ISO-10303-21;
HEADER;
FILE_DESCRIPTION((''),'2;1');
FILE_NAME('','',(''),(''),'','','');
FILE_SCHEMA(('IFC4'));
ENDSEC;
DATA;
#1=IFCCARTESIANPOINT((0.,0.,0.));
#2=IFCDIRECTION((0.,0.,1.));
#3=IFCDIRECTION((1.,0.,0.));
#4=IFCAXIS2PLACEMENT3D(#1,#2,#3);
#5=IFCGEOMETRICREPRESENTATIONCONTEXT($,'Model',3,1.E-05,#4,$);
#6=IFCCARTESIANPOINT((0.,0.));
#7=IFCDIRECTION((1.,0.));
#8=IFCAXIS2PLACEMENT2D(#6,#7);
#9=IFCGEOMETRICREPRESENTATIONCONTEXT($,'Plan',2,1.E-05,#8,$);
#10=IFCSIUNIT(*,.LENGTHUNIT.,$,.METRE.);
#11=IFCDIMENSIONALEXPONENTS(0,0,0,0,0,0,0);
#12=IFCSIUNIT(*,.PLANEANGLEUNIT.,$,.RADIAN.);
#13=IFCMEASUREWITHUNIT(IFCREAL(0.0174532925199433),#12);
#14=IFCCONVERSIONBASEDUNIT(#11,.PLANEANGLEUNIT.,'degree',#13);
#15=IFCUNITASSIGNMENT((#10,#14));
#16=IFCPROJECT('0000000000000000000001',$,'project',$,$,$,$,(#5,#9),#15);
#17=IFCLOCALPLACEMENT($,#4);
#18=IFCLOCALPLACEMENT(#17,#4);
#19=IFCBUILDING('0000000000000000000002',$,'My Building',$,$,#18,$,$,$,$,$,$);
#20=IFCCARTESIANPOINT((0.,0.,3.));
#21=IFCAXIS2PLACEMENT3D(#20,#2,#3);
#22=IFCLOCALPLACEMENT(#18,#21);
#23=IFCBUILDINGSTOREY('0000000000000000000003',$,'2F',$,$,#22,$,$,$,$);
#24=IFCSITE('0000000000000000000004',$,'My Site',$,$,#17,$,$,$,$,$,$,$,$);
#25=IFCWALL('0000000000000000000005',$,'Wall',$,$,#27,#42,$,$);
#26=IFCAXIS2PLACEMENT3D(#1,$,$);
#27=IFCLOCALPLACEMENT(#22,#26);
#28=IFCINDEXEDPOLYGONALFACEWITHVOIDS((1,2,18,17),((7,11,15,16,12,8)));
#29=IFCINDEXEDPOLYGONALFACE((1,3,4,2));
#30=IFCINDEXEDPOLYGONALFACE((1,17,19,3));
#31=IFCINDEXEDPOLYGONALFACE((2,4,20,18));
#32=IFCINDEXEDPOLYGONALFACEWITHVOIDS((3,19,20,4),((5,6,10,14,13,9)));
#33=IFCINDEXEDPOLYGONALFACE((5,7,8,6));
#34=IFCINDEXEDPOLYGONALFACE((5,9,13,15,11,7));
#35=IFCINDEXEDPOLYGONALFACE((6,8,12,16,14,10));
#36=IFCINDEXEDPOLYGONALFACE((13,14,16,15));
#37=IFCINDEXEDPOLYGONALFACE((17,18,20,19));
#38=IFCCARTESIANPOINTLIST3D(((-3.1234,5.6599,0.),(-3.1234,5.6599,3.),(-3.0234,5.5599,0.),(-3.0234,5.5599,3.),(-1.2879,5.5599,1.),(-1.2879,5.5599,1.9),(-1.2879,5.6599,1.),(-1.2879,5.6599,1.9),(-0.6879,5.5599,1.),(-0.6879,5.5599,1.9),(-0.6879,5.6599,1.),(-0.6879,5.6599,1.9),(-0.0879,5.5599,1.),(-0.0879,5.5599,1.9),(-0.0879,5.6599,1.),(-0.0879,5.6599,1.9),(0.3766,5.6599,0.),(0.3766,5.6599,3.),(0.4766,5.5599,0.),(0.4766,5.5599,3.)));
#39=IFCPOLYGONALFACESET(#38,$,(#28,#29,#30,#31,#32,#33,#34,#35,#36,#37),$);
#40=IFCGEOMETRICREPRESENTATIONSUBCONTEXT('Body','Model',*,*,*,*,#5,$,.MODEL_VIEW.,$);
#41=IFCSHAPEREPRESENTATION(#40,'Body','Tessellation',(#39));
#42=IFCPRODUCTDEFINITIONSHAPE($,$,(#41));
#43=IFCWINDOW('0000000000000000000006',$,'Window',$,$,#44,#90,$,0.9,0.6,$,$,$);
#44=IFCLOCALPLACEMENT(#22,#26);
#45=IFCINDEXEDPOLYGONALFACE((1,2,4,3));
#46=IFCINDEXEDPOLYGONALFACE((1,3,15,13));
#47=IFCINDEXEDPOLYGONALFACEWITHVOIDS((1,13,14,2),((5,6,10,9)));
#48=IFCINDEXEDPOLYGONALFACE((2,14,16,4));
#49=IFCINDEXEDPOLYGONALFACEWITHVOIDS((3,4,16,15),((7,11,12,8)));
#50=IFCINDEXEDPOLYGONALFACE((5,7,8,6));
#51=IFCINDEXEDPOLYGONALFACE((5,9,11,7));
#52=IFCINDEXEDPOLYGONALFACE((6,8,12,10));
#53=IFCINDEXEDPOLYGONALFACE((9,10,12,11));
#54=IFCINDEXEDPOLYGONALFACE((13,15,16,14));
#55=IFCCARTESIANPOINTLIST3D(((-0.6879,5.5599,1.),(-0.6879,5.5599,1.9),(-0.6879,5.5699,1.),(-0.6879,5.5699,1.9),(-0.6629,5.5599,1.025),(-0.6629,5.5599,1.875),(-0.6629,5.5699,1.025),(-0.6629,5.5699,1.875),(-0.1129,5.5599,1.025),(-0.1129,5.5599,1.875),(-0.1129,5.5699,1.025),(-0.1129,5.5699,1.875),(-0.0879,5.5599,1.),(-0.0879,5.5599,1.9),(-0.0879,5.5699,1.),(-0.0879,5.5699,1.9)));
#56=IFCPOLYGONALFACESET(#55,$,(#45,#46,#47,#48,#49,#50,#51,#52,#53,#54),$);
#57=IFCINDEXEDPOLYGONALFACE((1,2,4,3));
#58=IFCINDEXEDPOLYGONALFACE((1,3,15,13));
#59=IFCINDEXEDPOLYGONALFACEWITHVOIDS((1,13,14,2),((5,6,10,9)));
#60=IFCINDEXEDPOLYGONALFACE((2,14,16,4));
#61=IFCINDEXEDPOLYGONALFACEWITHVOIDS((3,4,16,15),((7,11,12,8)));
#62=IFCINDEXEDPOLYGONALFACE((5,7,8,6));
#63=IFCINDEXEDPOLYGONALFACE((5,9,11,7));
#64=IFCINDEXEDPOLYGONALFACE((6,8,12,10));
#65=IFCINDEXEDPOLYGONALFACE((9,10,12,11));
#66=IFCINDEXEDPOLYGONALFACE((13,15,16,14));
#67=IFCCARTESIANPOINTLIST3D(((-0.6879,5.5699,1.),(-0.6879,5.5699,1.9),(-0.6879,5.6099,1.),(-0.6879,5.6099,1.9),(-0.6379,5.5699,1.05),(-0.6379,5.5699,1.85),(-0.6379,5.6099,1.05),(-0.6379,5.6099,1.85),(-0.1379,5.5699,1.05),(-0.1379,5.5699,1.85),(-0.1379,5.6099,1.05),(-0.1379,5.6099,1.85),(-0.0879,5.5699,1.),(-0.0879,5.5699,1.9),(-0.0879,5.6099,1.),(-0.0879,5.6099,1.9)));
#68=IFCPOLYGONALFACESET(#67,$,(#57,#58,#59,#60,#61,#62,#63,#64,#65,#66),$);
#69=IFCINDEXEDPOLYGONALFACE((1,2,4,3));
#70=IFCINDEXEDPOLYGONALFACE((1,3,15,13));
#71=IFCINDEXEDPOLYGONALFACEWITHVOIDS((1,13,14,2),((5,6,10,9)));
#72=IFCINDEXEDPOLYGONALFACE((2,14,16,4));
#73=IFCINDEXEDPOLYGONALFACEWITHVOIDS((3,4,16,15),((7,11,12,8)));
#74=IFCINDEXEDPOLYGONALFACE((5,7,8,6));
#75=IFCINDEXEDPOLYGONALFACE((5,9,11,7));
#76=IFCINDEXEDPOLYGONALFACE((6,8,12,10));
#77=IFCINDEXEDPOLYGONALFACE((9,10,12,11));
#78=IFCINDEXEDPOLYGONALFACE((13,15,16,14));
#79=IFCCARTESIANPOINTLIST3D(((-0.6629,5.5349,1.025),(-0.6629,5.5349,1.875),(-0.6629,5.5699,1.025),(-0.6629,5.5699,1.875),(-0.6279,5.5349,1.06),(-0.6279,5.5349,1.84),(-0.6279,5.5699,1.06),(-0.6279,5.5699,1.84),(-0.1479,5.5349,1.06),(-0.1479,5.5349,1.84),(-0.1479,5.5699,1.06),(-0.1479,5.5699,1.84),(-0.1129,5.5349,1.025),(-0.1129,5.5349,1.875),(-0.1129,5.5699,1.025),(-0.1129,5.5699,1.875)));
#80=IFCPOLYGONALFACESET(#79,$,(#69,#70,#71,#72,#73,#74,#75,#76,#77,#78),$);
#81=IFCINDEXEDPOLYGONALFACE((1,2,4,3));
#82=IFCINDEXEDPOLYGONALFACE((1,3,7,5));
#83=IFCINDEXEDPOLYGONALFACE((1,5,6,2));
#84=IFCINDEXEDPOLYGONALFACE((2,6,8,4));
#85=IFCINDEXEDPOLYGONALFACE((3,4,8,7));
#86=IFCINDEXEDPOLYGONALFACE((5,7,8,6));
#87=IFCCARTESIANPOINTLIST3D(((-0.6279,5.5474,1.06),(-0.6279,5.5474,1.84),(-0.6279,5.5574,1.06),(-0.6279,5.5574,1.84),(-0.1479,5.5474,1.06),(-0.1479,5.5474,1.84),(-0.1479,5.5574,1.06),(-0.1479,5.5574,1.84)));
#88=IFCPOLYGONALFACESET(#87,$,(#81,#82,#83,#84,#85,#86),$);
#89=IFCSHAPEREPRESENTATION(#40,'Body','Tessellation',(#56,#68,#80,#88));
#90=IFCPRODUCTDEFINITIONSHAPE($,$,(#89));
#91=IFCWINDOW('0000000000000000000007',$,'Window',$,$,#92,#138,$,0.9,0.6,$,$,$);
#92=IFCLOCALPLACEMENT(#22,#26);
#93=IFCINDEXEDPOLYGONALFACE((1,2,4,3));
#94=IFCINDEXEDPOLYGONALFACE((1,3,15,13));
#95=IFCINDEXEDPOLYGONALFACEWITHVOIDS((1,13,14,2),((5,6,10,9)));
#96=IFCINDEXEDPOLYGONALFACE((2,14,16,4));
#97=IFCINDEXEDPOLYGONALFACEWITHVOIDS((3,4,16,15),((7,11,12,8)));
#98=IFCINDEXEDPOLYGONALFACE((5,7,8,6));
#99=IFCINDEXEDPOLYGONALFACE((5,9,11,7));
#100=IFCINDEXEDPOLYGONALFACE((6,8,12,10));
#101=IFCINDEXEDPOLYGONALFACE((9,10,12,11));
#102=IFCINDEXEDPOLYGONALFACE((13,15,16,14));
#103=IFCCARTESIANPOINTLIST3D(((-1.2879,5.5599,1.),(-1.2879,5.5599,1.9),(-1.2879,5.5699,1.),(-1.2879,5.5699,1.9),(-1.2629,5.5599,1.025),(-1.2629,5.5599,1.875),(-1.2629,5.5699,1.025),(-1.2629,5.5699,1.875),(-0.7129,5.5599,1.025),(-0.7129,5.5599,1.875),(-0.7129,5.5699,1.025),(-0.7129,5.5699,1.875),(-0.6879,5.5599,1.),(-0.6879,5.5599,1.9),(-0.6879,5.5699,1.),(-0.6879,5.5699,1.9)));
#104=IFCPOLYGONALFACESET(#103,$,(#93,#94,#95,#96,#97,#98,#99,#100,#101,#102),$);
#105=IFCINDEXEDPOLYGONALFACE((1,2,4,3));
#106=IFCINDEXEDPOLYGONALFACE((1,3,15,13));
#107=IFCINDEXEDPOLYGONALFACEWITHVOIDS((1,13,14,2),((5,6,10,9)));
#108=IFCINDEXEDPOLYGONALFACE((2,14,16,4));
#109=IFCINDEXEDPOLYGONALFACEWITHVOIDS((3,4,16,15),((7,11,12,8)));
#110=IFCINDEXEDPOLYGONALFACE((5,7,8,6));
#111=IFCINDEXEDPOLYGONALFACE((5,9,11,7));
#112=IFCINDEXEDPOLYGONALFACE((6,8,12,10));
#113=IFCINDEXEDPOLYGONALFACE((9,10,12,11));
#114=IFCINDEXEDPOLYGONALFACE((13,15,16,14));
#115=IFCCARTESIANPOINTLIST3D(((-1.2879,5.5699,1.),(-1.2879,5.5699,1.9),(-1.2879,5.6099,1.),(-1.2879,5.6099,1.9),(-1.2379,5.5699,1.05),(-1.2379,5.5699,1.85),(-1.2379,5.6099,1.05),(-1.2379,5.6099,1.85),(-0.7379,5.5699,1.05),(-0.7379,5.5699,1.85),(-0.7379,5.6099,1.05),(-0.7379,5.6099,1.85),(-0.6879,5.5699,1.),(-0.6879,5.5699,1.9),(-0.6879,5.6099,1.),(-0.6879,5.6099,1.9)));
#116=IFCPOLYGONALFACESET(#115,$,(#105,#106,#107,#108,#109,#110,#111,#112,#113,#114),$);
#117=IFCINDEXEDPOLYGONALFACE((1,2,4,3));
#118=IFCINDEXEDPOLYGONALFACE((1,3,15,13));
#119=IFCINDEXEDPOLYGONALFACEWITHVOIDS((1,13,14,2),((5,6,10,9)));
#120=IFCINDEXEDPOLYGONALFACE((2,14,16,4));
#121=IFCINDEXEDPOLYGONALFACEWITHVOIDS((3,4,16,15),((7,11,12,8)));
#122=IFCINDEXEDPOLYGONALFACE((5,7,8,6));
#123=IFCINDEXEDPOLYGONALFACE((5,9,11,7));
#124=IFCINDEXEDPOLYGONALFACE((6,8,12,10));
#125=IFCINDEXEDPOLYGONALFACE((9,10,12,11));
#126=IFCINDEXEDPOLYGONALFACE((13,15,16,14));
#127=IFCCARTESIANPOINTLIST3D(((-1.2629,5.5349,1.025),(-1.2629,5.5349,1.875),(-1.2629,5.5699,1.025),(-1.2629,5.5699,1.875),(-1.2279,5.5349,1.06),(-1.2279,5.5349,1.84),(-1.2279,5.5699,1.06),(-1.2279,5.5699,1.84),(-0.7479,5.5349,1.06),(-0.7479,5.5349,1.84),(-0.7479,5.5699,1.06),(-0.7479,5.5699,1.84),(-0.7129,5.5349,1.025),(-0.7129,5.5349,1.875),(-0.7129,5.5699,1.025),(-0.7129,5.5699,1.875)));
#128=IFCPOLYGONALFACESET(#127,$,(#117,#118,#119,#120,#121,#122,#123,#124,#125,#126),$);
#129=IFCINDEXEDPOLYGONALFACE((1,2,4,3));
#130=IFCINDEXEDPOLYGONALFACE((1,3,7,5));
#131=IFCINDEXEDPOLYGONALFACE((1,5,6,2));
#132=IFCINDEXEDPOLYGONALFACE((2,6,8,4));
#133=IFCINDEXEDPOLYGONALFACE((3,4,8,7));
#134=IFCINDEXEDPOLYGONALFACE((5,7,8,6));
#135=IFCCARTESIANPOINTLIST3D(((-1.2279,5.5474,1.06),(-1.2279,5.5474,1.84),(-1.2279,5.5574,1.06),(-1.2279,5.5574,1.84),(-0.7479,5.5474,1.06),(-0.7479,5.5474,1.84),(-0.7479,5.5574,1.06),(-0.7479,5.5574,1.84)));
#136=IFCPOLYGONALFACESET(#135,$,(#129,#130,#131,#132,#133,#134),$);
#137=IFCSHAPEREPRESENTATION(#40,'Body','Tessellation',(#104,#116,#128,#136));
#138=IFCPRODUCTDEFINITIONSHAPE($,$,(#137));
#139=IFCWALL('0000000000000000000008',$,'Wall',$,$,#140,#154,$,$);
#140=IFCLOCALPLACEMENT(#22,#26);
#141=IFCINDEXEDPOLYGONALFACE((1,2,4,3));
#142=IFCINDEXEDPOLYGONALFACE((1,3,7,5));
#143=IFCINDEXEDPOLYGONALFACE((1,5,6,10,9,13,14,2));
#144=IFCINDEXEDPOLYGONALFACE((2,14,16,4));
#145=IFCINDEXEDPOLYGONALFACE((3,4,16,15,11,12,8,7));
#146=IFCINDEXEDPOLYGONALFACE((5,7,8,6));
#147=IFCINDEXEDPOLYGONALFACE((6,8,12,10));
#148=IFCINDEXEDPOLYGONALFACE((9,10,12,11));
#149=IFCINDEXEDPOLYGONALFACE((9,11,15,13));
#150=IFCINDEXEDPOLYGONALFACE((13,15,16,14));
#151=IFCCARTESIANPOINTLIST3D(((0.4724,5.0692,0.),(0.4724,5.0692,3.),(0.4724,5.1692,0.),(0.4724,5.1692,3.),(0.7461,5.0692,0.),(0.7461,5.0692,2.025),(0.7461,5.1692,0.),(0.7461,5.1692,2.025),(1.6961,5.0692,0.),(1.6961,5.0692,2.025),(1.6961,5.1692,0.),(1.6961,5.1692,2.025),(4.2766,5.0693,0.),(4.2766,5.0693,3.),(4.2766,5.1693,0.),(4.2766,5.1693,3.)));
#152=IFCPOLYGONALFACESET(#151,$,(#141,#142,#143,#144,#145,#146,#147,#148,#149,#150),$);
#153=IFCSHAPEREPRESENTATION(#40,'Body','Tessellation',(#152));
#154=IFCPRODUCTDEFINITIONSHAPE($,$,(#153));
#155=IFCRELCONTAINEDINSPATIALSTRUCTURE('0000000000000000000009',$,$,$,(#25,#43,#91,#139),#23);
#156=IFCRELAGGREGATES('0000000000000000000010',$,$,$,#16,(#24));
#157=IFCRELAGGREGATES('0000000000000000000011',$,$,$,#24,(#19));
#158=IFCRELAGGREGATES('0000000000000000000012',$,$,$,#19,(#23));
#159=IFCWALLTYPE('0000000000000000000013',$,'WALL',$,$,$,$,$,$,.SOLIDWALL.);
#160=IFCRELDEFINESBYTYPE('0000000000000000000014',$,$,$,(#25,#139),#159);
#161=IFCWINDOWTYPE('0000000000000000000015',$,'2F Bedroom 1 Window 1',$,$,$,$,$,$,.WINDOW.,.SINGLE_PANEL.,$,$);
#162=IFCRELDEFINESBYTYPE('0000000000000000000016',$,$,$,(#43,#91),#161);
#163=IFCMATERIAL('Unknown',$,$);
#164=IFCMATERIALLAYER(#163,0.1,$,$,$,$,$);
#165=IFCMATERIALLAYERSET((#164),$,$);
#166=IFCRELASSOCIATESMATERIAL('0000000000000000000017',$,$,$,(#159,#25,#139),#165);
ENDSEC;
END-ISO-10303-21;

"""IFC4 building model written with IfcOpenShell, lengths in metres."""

from ifc_helpers import new_model, entity, si_unit, converted_unit, frame, origin_with_axes, origin_2d_with_axis, place, context, subcontext, project, spatial, line, indexed_curve, outline, extrude, shape, source, transform, mapped, material, layer, layer_set, layer_usage, type_object, type_shapes, element, fill, save


model = new_model("IFC4")

# Units and contexts
model_context = context("Model", 3, precision=1e-05, world=origin_with_axes())
plan_context = context("Plan", 2, precision=1e-05, world=origin_2d_with_axis())
body_context_1 = subcontext(model_context, "Body", "Model", "MODEL_VIEW")
body_context_2 = subcontext(plan_context, "Body", "Plan", "PLAN_VIEW")
ifc_project = project(units=[si_unit("LENGTHUNIT", "METRE"), converted_unit("PLANEANGLEUNIT", "degree", entity("IfcReal", 0.0174532925199433), si_unit("PLANEANGLEUNIT", "RADIAN"), dimensions=[0, 0, 0, 0, 0, 0, 0])], contexts=[model_context, plan_context])

# Site, building, storey
site_placement = place(None, origin_with_axes())
site = spatial("IfcSite", under=ifc_project, at=site_placement, Name="My Site")
building_placement = place(site_placement, origin_with_axes())
building = spatial("IfcBuilding", under=site, at=building_placement, Name="My Building")
storey_placement = place(building_placement, frame((0.0, 0.0, 3.0), z_axis=(0.0, 0.0, 1.0), x_axis=(1.0, 0.0, 0.0)))
storey = spatial("IfcBuildingStorey", under=building, at=storey_placement, Name="2F")

# Shared definitions
ifc_material = material(Name="Unknown")

# Shared definitions
ifc_layer_1 = layer(ifc_material, 0.1)
ifc_layer_set_1 = layer_set([ifc_layer_1])
wall_type = type_object("IfcWallType", Name="WALL", PredefinedType="SOLIDWALL", material=ifc_layer_set_1)

# Wall, openings, windows
ifc_layer_usage_1 = layer_usage(ifc_layer_set_1, "AXIS2", "POSITIVE", 0.0)
wall_1_placement = place(storey_placement, frame((0.3766, 5.6599, 0.0), z_axis=(0.0, 0.0, 1.0), x_axis=(-1.0, 0.0, 0.0)))
wall_1 = element("IfcWall", 1, at=wall_1_placement, inside=storey, type_object=wall_type, material=ifc_layer_usage_1, Name="Wall", context=body_context_1, shape_type="SweptSolid", body=[
    extrude(outline(indexed_curve([(0.0, 0.0), (-0.1, 0.1), (3.4, 0.1), (3.5, 0.0)], segments=[line(1, 2, 3, 4, 1)])), origin_with_axes(), (0.0, 0.0, 1.0), 3.0),
])
shared_shape_1 = source(origin_with_axes(), body_context_1, "Body", "SweptSolid", [
    extrude(outline(indexed_curve([(0.0, 0.0), (0.6, 0.0), (0.6, 0.9), (0.0, 0.9)], segments=[line(1, 2, 3, 4, 1)])), frame((0.0, -0.6, 0.0), z_axis=(0.0, -1.0, 0.0), x_axis=(1.0, 0.0, 0.0)), (0.0, 0.0, -1.0), 1.2),
])
opening_1_placement = place(wall_1_placement, frame((0.4645, 0.0, 1.0), z_axis=(0.0, 0.0, 1.0), x_axis=(1.0, 0.0, 0.0)))
opening_1 = element("IfcOpeningElement", 2, at=opening_1_placement, cuts=wall_1, PredefinedType="OPENING", context=body_context_1, shape_type="MappedRepresentation", body=[
    mapped(shared_shape_1, transform((0.0, 0.0, 0.0), x_axis=(1.0, 0.0, 0.0), y_axis=(0.0, 1.0, 0.0), z_axis=(0.0, 0.0, 1.0), scale=1.0)),
])
opening_2_placement = place(wall_1_placement, frame((1.0645, 0.0, 1.0), z_axis=(0.0, 0.0, 1.0), x_axis=(1.0, 0.0, 0.0)))
opening_2 = element("IfcOpeningElement", 3, at=opening_2_placement, cuts=wall_1, PredefinedType="OPENING", context=body_context_1, shape_type="MappedRepresentation", body=[
    mapped(shared_shape_1, transform((0.0, 0.0, 0.0), x_axis=(1.0, 0.0, 0.0), y_axis=(0.0, 1.0, 0.0), z_axis=(0.0, 0.0, 1.0), scale=1.0)),
])
window_type_1 = type_object("IfcWindowType", Name="2F Bedroom 1 Window 1", PartitioningType="SINGLE_PANEL", PredefinedType="WINDOW")
shared_shape_2 = source(origin_with_axes(), body_context_1, "Body", "SweptSolid", [
    extrude(outline(indexed_curve([(0.0, 0.0), (0.6, 0.0), (0.6, 0.9), (0.0, 0.9)], segments=[line(1, 2, 3, 4, 1)]), holes=[indexed_curve([(0.025, 0.025), (0.575, 0.025), (0.575, 0.875), (0.025, 0.875)], segments=[line(1, 2, 3, 4, 1)])]), frame((0.0, 0.09, 0.0), z_axis=(0.0, -1.0, 0.0), x_axis=(1.0, 0.0, 0.0)), (0.0, 0.0, -1.0), 0.01),
    extrude(outline(indexed_curve([(0.0, 0.0), (0.6, 0.0), (0.6, 0.9), (0.0, 0.9)], segments=[line(1, 2, 3, 4, 1)]), holes=[indexed_curve([(0.05, 0.05), (0.55, 0.05), (0.55, 0.85), (0.05, 0.85)], segments=[line(1, 2, 3, 4, 1)])]), frame((0.0, 0.05, 0.0), z_axis=(0.0, -1.0, 0.0), x_axis=(1.0, 0.0, 0.0)), (0.0, 0.0, -1.0), 0.04),
    extrude(outline(indexed_curve([(0.0, 0.0), (0.55, 0.0), (0.55, 0.85), (0.0, 0.85)], segments=[line(1, 2, 3, 4, 1)]), holes=[indexed_curve([(0.035, 0.035), (0.515, 0.035), (0.515, 0.815), (0.035, 0.815)], segments=[line(1, 2, 3, 4, 1)])]), frame((0.025, 0.09, 0.025), z_axis=(0.0, -1.0, 0.0), x_axis=(1.0, 0.0, 0.0)), (0.0, 0.0, -1.0), 0.035),
    extrude(outline(indexed_curve([(0.035, 0.035), (0.515, 0.035), (0.515, 0.815), (0.035, 0.815)], segments=[line(1, 2, 3, 4, 1)])), frame((0.025, 0.1025, 0.025), z_axis=(0.0, -1.0, 0.0), x_axis=(1.0, 0.0, 0.0)), (0.0, 0.0, -1.0), 0.01),
])
shared_shape_3 = source(origin_with_axes(), body_context_2, "Body", "Curve2D", [
    entity("IfcIndexedPolyCurve", entity("IfcCartesianPointList2D", [[0.05, 0.05], [0.55, 0.05]])),
    entity("IfcIndexedPolyCurve", entity("IfcCartesianPointList2D", [[0.0, 0.1], [0.025, 0.1], [0.025, 0.09], [0.05, 0.09], [0.05, 0.05], [0.0, 0.05]]), [entity("IfcLineIndex", [1, 2, 3, 4, 5, 6, 1])]),
    entity("IfcIndexedPolyCurve", entity("IfcCartesianPointList2D", [[0.6, 0.1], [0.575, 0.1], [0.575, 0.09], [0.55, 0.09], [0.55, 0.05], [0.6, 0.05]]), [entity("IfcLineIndex", [1, 2, 3, 4, 5, 6, 1])]),
    entity("IfcIndexedPolyCurve", entity("IfcCartesianPointList2D", [[0.025, 0.09], [0.06, 0.09], [0.06, 0.125], [0.025, 0.125]]), [entity("IfcLineIndex", [1, 2, 3, 4, 1])]),
    entity("IfcIndexedPolyCurve", entity("IfcCartesianPointList2D", [[0.575, 0.09], [0.54, 0.09], [0.54, 0.125], [0.575, 0.125]]), [entity("IfcLineIndex", [1, 2, 3, 4, 1])]),
    entity("IfcIndexedPolyCurve", entity("IfcCartesianPointList2D", [[0.06, 0.09], [0.54, 0.09]])),
    entity("IfcIndexedPolyCurve", entity("IfcCartesianPointList2D", [[0.06, 0.125], [0.54, 0.125]])),
    entity("IfcIndexedPolyCurve", entity("IfcCartesianPointList2D", [[0.06, 0.1075], [0.54, 0.1075]])),
])
type_shapes(window_type_1, [shared_shape_2, shared_shape_3])
window_1_placement = place(opening_1_placement, frame((0.0, 0.0, 0.0), z_axis=(0.0, 0.0, 1.0), x_axis=(1.0, 0.0, 0.0)))
window_1 = element("IfcWindow", 4, at=window_1_placement, inside=storey, type_object=window_type_1, Name="Window", OverallHeight=0.9, OverallWidth=0.6, shapes=[
    shape(body_context_1, "Body", "MappedRepresentation", [mapped(shared_shape_2, transform((0.0, 0.0, 0.0), x_axis=(1.0, 0.0, 0.0), y_axis=(0.0, 1.0, 0.0), z_axis=(0.0, 0.0, 1.0), scale=1.0))]),
    shape(body_context_2, "Body", "MappedRepresentation", [mapped(shared_shape_3, transform((0.0, 0.0, 0.0), x_axis=(1.0, 0.0, 0.0), y_axis=(0.0, 1.0, 0.0), z_axis=(0.0, 0.0, 1.0), scale=1.0))]),
])
fill(opening_1, window_1)
window_2_placement = place(opening_2_placement, frame((0.0, 0.0, 0.0), z_axis=(0.0, 0.0, 1.0), x_axis=(1.0, 0.0, 0.0)))
window_2 = element("IfcWindow", 5, at=window_2_placement, inside=storey, type_object=window_type_1, Name="Window", OverallHeight=0.9, OverallWidth=0.6, shapes=[
    shape(body_context_1, "Body", "MappedRepresentation", [mapped(shared_shape_2, transform((0.0, 0.0, 0.0), x_axis=(1.0, 0.0, 0.0), y_axis=(0.0, 1.0, 0.0), z_axis=(0.0, 0.0, 1.0), scale=1.0))]),
    shape(body_context_2, "Body", "MappedRepresentation", [mapped(shared_shape_3, transform((0.0, 0.0, 0.0), x_axis=(1.0, 0.0, 0.0), y_axis=(0.0, 1.0, 0.0), z_axis=(0.0, 0.0, 1.0), scale=1.0))]),
])
fill(opening_2, window_2)

# Wall, opening
ifc_layer_usage_2 = layer_usage(ifc_layer_set_1, "AXIS2", "POSITIVE", 0.0)
wall_2_placement = place(storey_placement, frame((4.2766, 5.1693, 0.0), z_axis=(0.0, 0.0, 1.0), x_axis=(-1.0, -0.000042, 0.0)))
wall_2 = element("IfcWall", 6, at=wall_2_placement, inside=storey, type_object=wall_type, material=ifc_layer_usage_2, Name="Wall", context=body_context_1, shape_type="SweptSolid", body=[
    extrude(outline(indexed_curve([(0.0, 0.0), (0.0, 0.1), (3.8042, 0.1), (3.8042, 0.0)], segments=[line(1, 2, 3, 4, 1)])), origin_with_axes(), (0.0, 0.0, 1.0), 3.0),
])
shared_shape_4 = source(origin_with_axes(), body_context_1, "Body", "SweptSolid", [
    extrude(outline(indexed_curve([(0.0, 0.0), (0.95, 0.0), (0.95, 2.025), (0.0, 2.025)], segments=[line(1, 2, 3, 4, 1)])), frame((-0.025, -0.6, 0.0), z_axis=(0.0, -1.0, 0.0), x_axis=(1.0, 0.0, 0.0)), (0.0, 0.0, -1.0), 1.2),
])
opening_3_placement = place(wall_2_placement, frame((2.6055, 0.0, 0.0), z_axis=(0.0, 0.0, 1.0), x_axis=(1.0, 0.0, 0.0)))
element("IfcOpeningElement", 7, at=opening_3_placement, cuts=wall_2, PredefinedType="OPENING", context=body_context_1, shape_type="MappedRepresentation", body=[
    mapped(shared_shape_4, transform((0.0, 0.0, 0.0), x_axis=(1.0, 0.0, 0.0), y_axis=(0.0, 1.0, 0.0), z_axis=(0.0, 0.0, 1.0), scale=1.0)),
])

save(model, "model.ifc")
